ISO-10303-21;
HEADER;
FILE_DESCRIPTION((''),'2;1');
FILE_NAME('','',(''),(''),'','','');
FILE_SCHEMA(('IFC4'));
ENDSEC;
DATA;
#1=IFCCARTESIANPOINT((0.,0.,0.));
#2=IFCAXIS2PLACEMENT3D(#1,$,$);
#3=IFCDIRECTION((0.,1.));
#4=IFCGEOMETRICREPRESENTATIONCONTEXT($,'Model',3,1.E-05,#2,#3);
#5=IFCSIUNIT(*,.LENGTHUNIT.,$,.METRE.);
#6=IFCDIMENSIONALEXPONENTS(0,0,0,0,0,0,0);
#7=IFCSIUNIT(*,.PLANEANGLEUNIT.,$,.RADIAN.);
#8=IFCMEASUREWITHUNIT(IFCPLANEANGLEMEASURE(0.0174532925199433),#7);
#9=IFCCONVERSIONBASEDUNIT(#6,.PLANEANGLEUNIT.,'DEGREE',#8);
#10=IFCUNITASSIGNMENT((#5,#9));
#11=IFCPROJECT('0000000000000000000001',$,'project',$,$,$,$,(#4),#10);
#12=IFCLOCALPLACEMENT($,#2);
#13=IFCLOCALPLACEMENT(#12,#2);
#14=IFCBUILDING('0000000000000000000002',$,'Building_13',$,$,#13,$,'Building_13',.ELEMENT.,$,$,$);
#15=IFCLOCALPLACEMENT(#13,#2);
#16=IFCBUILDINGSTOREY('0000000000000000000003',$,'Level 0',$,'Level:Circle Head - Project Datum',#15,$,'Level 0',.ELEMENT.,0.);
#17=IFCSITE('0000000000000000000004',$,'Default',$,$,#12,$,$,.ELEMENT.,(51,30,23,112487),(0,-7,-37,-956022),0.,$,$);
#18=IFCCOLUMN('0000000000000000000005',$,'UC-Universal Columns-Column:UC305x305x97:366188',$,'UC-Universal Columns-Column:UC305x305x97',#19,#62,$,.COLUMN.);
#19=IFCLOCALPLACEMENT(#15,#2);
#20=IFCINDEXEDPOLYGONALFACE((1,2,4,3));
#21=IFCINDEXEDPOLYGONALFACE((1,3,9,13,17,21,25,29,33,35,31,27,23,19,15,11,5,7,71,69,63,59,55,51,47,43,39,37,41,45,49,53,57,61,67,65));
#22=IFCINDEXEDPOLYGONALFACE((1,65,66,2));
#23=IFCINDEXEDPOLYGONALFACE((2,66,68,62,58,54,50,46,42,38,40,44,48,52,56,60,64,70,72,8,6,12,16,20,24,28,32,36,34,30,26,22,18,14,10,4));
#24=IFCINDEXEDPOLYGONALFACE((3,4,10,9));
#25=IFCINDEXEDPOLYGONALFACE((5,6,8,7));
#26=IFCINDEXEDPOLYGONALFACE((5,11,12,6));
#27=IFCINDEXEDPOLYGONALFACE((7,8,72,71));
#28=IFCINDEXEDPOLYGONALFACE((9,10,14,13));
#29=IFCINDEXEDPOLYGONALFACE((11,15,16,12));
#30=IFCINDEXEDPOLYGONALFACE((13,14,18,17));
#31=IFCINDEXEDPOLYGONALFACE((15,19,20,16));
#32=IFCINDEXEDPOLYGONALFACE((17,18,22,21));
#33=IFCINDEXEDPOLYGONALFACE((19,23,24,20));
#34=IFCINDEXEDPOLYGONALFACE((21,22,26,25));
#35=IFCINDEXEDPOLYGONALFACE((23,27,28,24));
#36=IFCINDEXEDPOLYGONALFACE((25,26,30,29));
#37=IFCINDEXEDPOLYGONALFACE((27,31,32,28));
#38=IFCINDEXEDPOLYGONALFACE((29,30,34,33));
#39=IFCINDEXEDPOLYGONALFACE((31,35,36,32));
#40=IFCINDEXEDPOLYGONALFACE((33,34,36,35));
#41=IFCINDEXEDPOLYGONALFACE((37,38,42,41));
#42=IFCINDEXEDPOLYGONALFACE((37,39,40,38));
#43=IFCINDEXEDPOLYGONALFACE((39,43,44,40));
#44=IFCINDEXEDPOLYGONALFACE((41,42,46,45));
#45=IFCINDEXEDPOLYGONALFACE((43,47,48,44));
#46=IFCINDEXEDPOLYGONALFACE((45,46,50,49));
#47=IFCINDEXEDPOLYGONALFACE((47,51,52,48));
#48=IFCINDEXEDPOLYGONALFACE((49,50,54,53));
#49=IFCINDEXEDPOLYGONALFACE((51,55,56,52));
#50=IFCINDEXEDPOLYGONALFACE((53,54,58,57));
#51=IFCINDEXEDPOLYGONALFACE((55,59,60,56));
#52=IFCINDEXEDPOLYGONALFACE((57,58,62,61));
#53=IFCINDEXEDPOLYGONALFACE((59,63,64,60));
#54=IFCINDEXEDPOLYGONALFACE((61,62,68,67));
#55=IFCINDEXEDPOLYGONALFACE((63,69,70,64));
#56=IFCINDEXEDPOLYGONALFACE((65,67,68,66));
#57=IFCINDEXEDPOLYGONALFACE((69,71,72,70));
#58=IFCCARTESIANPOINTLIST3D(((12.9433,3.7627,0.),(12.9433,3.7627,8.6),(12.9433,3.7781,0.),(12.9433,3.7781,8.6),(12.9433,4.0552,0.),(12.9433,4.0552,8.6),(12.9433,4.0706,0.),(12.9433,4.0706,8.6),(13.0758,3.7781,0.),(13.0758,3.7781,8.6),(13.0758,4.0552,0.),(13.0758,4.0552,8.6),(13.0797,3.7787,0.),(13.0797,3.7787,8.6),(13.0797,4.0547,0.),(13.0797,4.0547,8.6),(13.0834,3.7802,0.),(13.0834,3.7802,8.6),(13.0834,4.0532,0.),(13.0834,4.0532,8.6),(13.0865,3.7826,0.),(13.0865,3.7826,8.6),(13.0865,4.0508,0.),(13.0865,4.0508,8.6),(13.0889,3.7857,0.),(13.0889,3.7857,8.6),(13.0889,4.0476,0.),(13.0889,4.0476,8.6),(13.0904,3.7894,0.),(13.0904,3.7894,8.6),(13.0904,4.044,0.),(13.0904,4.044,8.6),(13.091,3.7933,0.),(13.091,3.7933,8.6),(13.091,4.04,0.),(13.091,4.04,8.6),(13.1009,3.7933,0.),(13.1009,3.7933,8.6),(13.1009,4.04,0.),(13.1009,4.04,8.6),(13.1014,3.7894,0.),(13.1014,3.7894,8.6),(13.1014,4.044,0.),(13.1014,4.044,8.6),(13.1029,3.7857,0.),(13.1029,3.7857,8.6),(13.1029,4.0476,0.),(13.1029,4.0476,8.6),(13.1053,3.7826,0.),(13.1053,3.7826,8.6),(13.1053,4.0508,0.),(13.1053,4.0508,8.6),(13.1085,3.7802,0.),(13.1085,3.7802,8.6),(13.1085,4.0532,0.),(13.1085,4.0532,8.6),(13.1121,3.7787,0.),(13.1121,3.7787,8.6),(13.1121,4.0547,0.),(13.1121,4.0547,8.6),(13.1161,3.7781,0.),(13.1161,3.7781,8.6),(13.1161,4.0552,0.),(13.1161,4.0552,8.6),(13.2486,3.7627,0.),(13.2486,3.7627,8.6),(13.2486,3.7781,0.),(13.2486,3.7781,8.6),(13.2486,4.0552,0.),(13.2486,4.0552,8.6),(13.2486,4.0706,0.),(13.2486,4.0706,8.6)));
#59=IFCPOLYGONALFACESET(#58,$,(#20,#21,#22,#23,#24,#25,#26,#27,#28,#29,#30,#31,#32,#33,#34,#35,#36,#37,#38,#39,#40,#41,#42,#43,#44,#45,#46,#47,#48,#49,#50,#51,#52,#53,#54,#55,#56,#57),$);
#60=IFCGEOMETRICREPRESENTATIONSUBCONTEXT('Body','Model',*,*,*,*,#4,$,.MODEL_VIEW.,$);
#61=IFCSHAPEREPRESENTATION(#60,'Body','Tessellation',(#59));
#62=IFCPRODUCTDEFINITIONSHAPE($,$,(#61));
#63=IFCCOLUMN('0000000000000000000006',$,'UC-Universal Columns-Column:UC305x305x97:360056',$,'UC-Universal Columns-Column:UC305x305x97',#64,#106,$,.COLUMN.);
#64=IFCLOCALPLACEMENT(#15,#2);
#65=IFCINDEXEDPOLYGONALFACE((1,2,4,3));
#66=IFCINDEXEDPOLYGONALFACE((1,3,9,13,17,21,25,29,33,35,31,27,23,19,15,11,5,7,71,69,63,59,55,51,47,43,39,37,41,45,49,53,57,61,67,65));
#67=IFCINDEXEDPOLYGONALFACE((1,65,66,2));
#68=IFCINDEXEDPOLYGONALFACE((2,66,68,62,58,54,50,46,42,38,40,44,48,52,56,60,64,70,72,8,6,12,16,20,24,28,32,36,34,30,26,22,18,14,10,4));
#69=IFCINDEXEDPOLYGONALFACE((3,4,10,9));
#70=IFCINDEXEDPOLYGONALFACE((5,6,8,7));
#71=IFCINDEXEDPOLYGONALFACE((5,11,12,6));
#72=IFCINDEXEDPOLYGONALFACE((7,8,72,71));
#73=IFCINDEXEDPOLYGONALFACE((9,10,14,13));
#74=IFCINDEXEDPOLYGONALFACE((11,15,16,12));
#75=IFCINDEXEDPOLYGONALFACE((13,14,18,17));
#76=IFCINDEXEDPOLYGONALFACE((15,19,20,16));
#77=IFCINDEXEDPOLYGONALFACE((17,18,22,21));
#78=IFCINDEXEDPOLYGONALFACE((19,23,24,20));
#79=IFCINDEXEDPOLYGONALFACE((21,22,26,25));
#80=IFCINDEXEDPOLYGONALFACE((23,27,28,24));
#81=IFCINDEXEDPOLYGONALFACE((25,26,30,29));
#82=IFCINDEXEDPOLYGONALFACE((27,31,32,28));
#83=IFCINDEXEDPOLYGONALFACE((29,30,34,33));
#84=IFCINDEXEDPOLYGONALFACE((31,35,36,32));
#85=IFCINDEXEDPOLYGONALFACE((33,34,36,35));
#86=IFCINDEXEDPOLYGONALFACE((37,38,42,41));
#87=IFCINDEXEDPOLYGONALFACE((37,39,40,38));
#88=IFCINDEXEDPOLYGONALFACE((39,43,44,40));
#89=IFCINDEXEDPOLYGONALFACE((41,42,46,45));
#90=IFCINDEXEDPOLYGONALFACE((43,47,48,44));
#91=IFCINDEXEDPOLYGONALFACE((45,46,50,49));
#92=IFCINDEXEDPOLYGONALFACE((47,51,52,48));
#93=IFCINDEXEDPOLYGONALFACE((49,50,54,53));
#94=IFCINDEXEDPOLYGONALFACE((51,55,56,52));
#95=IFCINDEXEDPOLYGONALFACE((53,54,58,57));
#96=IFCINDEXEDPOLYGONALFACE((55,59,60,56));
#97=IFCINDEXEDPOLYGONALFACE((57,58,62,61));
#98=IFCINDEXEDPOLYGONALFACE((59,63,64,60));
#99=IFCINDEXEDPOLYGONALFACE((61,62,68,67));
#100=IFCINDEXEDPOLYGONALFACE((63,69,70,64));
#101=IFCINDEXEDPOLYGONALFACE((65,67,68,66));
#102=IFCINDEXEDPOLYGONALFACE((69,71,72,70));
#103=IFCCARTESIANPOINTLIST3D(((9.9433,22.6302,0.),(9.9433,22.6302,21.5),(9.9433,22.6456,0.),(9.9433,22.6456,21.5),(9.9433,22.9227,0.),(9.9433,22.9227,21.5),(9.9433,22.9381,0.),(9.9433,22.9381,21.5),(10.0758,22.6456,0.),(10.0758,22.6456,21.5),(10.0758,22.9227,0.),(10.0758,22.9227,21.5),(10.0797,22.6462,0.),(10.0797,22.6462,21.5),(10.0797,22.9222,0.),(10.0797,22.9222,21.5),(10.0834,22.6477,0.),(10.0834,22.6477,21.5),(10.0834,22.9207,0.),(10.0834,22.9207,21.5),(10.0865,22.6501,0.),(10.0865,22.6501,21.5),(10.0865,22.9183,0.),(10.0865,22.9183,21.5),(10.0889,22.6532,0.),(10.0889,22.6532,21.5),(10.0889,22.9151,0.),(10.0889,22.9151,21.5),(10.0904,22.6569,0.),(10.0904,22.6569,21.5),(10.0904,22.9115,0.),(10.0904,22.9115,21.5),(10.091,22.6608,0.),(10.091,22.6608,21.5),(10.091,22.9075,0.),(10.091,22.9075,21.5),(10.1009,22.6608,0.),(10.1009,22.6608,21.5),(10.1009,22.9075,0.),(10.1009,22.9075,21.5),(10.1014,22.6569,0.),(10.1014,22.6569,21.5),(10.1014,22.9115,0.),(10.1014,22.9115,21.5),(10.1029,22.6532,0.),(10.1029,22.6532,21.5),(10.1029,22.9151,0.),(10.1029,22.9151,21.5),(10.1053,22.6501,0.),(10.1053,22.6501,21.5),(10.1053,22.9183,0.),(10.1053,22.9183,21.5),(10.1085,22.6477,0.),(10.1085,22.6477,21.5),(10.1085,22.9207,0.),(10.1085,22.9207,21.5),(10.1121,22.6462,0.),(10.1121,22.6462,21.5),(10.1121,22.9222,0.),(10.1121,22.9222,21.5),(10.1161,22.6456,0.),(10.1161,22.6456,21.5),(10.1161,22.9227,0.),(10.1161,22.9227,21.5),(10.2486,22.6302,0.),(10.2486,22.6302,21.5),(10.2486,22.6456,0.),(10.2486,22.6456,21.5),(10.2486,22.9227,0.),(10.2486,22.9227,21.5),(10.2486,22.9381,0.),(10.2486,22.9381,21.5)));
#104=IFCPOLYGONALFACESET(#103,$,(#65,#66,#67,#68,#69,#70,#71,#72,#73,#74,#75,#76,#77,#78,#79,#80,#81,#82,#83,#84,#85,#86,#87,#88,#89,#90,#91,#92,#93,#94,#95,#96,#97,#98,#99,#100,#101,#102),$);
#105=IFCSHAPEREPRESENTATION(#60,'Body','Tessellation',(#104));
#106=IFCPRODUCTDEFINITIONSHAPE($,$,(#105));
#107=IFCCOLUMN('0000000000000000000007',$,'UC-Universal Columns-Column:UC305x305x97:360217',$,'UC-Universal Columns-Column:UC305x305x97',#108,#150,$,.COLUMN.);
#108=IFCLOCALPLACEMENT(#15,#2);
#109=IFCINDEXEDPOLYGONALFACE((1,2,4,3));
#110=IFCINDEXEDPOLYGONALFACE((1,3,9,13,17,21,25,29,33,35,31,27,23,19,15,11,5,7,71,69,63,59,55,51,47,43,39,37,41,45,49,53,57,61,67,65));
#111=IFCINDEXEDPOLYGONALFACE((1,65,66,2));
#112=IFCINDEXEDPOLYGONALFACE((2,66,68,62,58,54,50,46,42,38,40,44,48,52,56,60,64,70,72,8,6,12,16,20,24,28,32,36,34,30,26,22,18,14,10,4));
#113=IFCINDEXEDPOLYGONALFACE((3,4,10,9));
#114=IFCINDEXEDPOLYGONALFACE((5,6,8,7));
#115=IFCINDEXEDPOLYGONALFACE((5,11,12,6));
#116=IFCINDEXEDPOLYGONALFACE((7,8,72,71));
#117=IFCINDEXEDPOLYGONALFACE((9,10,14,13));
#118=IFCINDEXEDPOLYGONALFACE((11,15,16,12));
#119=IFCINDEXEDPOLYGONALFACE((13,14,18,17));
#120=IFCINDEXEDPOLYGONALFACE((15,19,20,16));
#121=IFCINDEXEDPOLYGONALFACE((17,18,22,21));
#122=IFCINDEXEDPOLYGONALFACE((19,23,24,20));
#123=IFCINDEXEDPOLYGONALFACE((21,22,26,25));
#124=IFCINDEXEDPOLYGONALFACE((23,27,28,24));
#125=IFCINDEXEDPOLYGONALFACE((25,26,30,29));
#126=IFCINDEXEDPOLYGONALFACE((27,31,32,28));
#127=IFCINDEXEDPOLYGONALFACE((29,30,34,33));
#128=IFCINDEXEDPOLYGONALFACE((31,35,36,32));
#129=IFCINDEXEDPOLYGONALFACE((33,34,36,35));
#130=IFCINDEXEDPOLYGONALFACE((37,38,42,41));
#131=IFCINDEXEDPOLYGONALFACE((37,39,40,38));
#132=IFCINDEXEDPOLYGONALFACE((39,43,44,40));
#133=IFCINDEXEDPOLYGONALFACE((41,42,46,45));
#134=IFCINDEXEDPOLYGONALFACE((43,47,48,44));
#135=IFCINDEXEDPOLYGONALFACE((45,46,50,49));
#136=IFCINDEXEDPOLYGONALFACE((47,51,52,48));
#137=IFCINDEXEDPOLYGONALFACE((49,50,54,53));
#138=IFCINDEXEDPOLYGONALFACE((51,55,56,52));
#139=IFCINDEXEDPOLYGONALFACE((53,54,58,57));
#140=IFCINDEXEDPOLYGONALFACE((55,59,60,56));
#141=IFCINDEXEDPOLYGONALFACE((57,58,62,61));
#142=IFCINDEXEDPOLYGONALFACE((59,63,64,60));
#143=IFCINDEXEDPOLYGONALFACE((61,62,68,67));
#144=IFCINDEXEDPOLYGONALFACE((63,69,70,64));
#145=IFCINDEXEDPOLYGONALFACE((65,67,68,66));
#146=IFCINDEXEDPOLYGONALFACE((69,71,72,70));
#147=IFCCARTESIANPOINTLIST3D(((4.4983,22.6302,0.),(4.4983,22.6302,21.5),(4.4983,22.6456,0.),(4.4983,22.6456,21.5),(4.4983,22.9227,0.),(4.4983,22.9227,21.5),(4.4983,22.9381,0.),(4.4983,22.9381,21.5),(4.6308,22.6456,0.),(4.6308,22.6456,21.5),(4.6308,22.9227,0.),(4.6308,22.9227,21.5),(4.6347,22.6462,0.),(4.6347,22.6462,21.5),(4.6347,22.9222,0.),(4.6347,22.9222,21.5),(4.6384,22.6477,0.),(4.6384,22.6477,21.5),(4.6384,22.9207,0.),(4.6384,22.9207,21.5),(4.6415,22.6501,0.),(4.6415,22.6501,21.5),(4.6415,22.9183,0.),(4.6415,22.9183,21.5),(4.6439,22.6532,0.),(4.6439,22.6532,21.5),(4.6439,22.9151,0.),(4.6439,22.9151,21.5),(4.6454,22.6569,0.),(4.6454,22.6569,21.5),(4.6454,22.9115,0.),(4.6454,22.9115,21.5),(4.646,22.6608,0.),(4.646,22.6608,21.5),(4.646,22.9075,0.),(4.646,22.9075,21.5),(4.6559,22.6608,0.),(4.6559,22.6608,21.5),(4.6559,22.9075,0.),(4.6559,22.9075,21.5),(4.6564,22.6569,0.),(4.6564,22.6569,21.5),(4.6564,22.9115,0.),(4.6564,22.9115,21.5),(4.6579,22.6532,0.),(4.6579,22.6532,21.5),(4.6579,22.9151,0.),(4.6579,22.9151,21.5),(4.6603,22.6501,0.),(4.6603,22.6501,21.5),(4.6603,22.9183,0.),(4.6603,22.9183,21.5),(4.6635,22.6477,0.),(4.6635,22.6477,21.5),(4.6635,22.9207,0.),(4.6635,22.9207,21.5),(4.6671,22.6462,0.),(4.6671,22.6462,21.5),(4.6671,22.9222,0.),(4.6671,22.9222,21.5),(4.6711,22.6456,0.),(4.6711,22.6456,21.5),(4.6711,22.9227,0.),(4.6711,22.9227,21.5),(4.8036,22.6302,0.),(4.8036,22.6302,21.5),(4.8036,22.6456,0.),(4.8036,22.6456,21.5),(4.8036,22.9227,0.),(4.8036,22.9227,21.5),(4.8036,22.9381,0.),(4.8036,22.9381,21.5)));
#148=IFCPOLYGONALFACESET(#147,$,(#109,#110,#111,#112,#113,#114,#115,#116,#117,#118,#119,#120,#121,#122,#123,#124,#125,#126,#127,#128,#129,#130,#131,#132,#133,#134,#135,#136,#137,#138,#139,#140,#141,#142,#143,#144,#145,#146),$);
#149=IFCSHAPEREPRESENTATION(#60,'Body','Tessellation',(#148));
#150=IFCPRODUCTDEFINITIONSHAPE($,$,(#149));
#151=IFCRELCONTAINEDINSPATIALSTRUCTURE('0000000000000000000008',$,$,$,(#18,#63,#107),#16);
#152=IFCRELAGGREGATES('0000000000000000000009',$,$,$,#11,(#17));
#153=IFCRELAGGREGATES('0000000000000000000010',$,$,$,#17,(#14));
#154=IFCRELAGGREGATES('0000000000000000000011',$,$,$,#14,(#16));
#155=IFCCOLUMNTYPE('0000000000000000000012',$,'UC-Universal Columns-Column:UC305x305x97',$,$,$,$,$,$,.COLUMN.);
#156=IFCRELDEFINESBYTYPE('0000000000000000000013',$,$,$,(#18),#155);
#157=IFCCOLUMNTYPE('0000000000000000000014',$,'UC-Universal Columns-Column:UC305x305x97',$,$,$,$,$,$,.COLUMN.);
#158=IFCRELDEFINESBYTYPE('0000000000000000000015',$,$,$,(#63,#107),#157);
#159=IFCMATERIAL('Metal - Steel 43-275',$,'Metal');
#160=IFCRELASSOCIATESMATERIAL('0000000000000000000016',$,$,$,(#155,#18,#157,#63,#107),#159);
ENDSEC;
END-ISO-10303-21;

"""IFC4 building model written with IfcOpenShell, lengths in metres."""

from ifc_helpers import new_model, entity, si_unit, converted_unit, direction, frame, origin, place, context, subcontext, project, spatial, line, arc, indexed_curve, outline, extrude, source, transform, mapped, material, type_object, type_shapes, element, save


model = new_model("IFC4")

# Units and contexts
model_context = context("Model", 3, precision=1e-05, world=origin(), true_north=direction((0.0, 1.0)))
body_context = subcontext(model_context, "Body", "Model", "MODEL_VIEW")
ifc_project = project(units=[si_unit("LENGTHUNIT", "METRE"), converted_unit("PLANEANGLEUNIT", "DEGREE", entity("IfcPlaneAngleMeasure", 0.0174532925199433), si_unit("PLANEANGLEUNIT", "RADIAN"), dimensions=[0, 0, 0, 0, 0, 0, 0])], contexts=[model_context])

# Site, building, storey
site_placement = place(None, origin())
site = spatial("IfcSite", under=ifc_project, at=site_placement, Name="Default", CompositionType="ELEMENT", RefLatitude=(51, 30, 23, 112487), RefLongitude=(0, -7, -37, -956022), RefElevation=0.0)
building_placement = place(site_placement, origin())
building = spatial("IfcBuilding", under=site, at=building_placement, Name="Building_13", LongName="Building_13", CompositionType="ELEMENT")
storey_placement = place(building_placement, origin())
storey = spatial("IfcBuildingStorey", under=building, at=storey_placement, Name="Level 0", ObjectType="Level:Circle Head - Project Datum", LongName="Level 0", CompositionType="ELEMENT", Elevation=0.0)

# Columns
ifc_material_1 = material(Name="Metal - Steel 43-275", Category="Metal")
column_type_1 = type_object("IfcColumnType", Name="UC-Universal Columns-Column:UC305x305x97", PredefinedType="COLUMN", material=ifc_material_1)
shared_shape_1 = source(origin(), body_context, "Body", "SweptSolid", [
    extrude(outline(indexed_curve([(-0.1527, -0.154), (0.1527, -0.154), (0.1527, -0.1386), (0.0202, -0.1386), (0.0094, -0.1341), (0.0049, -0.1234), (0.0049, 0.1234), (0.0094, 0.1341), (0.0202, 0.1386), (0.1527, 0.1386), (0.1527, 0.154), (-0.1527, 0.154), (-0.1527, 0.1386), (-0.0202, 0.1386), (-0.0094, 0.1341), (-0.005, 0.1234), (-0.005, -0.1234), (-0.0094, -0.1341), (-0.0202, -0.1386), (-0.1527, -0.1386)], segments=[line(1, 2, 3, 4), arc(4, 5, 6), line(6, 7), arc(7, 8, 9), line(9, 10, 11, 12, 13, 14), arc(14, 15, 16), line(16, 17), arc(17, 18, 19), line(19, 20, 1)], self_intersect=False)), frame((0.0, 0.0, 0.0), z_axis=(0.0, 0.0, 1.0), x_axis=(-1.0, 0.0, 0.0)), (0.0, 0.0, 1.0), 8.6),
])
type_shapes(column_type_1, [shared_shape_1])
for number, where, name in (
    (1, (13.0959, 3.9167, 0.0), "UC-Universal Columns-Column:UC305x305x97:366188"),
):
    element("IfcColumn", number, at=place(storey_placement, frame(where)), inside=storey, type_object=column_type_1, material=ifc_material_1, Name=name, ObjectType="UC-Universal Columns-Column:UC305x305x97", PredefinedType="COLUMN", context=body_context, shape_type="MappedRepresentation", body=[
        mapped(shared_shape_1, transform((0.0, 0.0, 0.0), scale=1.0)),
    ])
column_type_2 = type_object("IfcColumnType", Name="UC-Universal Columns-Column:UC305x305x97", PredefinedType="COLUMN", material=ifc_material_1)
shared_shape_2 = source(origin(), body_context, "Body", "SweptSolid", [
    extrude(outline(indexed_curve([(-0.1527, -0.154), (0.1527, -0.154), (0.1527, -0.1386), (0.0202, -0.1386), (0.0094, -0.1341), (0.0049, -0.1234), (0.0049, 0.1234), (0.0094, 0.1341), (0.0202, 0.1386), (0.1527, 0.1386), (0.1527, 0.154), (-0.1527, 0.154), (-0.1527, 0.1386), (-0.0202, 0.1386), (-0.0094, 0.1341), (-0.005, 0.1234), (-0.005, -0.1234), (-0.0094, -0.1341), (-0.0202, -0.1386), (-0.1527, -0.1386)], segments=[line(1, 2, 3, 4), arc(4, 5, 6), line(6, 7), arc(7, 8, 9), line(9, 10, 11, 12, 13, 14), arc(14, 15, 16), line(16, 17), arc(17, 18, 19), line(19, 20, 1)], self_intersect=False)), frame((0.0, 0.0, 0.0), z_axis=(0.0, 0.0, 1.0), x_axis=(-1.0, 0.0, 0.0)), (0.0, 0.0, 1.0), 21.5),
])
type_shapes(column_type_2, [shared_shape_2])
for number, where, name in (
    (2, (10.0959, 22.7842, 0.0), "UC-Universal Columns-Column:UC305x305x97:360056"),
    (3, (4.6509, 22.7842, 0.0), "UC-Universal Columns-Column:UC305x305x97:360217"),
):
    element("IfcColumn", number, at=place(storey_placement, frame(where)), inside=storey, type_object=column_type_2, material=ifc_material_1, Name=name, ObjectType="UC-Universal Columns-Column:UC305x305x97", PredefinedType="COLUMN", context=body_context, shape_type="MappedRepresentation", body=[
        mapped(shared_shape_2, transform((0.0, 0.0, 0.0), scale=1.0)),
    ])

save(model, "model.ifc")
